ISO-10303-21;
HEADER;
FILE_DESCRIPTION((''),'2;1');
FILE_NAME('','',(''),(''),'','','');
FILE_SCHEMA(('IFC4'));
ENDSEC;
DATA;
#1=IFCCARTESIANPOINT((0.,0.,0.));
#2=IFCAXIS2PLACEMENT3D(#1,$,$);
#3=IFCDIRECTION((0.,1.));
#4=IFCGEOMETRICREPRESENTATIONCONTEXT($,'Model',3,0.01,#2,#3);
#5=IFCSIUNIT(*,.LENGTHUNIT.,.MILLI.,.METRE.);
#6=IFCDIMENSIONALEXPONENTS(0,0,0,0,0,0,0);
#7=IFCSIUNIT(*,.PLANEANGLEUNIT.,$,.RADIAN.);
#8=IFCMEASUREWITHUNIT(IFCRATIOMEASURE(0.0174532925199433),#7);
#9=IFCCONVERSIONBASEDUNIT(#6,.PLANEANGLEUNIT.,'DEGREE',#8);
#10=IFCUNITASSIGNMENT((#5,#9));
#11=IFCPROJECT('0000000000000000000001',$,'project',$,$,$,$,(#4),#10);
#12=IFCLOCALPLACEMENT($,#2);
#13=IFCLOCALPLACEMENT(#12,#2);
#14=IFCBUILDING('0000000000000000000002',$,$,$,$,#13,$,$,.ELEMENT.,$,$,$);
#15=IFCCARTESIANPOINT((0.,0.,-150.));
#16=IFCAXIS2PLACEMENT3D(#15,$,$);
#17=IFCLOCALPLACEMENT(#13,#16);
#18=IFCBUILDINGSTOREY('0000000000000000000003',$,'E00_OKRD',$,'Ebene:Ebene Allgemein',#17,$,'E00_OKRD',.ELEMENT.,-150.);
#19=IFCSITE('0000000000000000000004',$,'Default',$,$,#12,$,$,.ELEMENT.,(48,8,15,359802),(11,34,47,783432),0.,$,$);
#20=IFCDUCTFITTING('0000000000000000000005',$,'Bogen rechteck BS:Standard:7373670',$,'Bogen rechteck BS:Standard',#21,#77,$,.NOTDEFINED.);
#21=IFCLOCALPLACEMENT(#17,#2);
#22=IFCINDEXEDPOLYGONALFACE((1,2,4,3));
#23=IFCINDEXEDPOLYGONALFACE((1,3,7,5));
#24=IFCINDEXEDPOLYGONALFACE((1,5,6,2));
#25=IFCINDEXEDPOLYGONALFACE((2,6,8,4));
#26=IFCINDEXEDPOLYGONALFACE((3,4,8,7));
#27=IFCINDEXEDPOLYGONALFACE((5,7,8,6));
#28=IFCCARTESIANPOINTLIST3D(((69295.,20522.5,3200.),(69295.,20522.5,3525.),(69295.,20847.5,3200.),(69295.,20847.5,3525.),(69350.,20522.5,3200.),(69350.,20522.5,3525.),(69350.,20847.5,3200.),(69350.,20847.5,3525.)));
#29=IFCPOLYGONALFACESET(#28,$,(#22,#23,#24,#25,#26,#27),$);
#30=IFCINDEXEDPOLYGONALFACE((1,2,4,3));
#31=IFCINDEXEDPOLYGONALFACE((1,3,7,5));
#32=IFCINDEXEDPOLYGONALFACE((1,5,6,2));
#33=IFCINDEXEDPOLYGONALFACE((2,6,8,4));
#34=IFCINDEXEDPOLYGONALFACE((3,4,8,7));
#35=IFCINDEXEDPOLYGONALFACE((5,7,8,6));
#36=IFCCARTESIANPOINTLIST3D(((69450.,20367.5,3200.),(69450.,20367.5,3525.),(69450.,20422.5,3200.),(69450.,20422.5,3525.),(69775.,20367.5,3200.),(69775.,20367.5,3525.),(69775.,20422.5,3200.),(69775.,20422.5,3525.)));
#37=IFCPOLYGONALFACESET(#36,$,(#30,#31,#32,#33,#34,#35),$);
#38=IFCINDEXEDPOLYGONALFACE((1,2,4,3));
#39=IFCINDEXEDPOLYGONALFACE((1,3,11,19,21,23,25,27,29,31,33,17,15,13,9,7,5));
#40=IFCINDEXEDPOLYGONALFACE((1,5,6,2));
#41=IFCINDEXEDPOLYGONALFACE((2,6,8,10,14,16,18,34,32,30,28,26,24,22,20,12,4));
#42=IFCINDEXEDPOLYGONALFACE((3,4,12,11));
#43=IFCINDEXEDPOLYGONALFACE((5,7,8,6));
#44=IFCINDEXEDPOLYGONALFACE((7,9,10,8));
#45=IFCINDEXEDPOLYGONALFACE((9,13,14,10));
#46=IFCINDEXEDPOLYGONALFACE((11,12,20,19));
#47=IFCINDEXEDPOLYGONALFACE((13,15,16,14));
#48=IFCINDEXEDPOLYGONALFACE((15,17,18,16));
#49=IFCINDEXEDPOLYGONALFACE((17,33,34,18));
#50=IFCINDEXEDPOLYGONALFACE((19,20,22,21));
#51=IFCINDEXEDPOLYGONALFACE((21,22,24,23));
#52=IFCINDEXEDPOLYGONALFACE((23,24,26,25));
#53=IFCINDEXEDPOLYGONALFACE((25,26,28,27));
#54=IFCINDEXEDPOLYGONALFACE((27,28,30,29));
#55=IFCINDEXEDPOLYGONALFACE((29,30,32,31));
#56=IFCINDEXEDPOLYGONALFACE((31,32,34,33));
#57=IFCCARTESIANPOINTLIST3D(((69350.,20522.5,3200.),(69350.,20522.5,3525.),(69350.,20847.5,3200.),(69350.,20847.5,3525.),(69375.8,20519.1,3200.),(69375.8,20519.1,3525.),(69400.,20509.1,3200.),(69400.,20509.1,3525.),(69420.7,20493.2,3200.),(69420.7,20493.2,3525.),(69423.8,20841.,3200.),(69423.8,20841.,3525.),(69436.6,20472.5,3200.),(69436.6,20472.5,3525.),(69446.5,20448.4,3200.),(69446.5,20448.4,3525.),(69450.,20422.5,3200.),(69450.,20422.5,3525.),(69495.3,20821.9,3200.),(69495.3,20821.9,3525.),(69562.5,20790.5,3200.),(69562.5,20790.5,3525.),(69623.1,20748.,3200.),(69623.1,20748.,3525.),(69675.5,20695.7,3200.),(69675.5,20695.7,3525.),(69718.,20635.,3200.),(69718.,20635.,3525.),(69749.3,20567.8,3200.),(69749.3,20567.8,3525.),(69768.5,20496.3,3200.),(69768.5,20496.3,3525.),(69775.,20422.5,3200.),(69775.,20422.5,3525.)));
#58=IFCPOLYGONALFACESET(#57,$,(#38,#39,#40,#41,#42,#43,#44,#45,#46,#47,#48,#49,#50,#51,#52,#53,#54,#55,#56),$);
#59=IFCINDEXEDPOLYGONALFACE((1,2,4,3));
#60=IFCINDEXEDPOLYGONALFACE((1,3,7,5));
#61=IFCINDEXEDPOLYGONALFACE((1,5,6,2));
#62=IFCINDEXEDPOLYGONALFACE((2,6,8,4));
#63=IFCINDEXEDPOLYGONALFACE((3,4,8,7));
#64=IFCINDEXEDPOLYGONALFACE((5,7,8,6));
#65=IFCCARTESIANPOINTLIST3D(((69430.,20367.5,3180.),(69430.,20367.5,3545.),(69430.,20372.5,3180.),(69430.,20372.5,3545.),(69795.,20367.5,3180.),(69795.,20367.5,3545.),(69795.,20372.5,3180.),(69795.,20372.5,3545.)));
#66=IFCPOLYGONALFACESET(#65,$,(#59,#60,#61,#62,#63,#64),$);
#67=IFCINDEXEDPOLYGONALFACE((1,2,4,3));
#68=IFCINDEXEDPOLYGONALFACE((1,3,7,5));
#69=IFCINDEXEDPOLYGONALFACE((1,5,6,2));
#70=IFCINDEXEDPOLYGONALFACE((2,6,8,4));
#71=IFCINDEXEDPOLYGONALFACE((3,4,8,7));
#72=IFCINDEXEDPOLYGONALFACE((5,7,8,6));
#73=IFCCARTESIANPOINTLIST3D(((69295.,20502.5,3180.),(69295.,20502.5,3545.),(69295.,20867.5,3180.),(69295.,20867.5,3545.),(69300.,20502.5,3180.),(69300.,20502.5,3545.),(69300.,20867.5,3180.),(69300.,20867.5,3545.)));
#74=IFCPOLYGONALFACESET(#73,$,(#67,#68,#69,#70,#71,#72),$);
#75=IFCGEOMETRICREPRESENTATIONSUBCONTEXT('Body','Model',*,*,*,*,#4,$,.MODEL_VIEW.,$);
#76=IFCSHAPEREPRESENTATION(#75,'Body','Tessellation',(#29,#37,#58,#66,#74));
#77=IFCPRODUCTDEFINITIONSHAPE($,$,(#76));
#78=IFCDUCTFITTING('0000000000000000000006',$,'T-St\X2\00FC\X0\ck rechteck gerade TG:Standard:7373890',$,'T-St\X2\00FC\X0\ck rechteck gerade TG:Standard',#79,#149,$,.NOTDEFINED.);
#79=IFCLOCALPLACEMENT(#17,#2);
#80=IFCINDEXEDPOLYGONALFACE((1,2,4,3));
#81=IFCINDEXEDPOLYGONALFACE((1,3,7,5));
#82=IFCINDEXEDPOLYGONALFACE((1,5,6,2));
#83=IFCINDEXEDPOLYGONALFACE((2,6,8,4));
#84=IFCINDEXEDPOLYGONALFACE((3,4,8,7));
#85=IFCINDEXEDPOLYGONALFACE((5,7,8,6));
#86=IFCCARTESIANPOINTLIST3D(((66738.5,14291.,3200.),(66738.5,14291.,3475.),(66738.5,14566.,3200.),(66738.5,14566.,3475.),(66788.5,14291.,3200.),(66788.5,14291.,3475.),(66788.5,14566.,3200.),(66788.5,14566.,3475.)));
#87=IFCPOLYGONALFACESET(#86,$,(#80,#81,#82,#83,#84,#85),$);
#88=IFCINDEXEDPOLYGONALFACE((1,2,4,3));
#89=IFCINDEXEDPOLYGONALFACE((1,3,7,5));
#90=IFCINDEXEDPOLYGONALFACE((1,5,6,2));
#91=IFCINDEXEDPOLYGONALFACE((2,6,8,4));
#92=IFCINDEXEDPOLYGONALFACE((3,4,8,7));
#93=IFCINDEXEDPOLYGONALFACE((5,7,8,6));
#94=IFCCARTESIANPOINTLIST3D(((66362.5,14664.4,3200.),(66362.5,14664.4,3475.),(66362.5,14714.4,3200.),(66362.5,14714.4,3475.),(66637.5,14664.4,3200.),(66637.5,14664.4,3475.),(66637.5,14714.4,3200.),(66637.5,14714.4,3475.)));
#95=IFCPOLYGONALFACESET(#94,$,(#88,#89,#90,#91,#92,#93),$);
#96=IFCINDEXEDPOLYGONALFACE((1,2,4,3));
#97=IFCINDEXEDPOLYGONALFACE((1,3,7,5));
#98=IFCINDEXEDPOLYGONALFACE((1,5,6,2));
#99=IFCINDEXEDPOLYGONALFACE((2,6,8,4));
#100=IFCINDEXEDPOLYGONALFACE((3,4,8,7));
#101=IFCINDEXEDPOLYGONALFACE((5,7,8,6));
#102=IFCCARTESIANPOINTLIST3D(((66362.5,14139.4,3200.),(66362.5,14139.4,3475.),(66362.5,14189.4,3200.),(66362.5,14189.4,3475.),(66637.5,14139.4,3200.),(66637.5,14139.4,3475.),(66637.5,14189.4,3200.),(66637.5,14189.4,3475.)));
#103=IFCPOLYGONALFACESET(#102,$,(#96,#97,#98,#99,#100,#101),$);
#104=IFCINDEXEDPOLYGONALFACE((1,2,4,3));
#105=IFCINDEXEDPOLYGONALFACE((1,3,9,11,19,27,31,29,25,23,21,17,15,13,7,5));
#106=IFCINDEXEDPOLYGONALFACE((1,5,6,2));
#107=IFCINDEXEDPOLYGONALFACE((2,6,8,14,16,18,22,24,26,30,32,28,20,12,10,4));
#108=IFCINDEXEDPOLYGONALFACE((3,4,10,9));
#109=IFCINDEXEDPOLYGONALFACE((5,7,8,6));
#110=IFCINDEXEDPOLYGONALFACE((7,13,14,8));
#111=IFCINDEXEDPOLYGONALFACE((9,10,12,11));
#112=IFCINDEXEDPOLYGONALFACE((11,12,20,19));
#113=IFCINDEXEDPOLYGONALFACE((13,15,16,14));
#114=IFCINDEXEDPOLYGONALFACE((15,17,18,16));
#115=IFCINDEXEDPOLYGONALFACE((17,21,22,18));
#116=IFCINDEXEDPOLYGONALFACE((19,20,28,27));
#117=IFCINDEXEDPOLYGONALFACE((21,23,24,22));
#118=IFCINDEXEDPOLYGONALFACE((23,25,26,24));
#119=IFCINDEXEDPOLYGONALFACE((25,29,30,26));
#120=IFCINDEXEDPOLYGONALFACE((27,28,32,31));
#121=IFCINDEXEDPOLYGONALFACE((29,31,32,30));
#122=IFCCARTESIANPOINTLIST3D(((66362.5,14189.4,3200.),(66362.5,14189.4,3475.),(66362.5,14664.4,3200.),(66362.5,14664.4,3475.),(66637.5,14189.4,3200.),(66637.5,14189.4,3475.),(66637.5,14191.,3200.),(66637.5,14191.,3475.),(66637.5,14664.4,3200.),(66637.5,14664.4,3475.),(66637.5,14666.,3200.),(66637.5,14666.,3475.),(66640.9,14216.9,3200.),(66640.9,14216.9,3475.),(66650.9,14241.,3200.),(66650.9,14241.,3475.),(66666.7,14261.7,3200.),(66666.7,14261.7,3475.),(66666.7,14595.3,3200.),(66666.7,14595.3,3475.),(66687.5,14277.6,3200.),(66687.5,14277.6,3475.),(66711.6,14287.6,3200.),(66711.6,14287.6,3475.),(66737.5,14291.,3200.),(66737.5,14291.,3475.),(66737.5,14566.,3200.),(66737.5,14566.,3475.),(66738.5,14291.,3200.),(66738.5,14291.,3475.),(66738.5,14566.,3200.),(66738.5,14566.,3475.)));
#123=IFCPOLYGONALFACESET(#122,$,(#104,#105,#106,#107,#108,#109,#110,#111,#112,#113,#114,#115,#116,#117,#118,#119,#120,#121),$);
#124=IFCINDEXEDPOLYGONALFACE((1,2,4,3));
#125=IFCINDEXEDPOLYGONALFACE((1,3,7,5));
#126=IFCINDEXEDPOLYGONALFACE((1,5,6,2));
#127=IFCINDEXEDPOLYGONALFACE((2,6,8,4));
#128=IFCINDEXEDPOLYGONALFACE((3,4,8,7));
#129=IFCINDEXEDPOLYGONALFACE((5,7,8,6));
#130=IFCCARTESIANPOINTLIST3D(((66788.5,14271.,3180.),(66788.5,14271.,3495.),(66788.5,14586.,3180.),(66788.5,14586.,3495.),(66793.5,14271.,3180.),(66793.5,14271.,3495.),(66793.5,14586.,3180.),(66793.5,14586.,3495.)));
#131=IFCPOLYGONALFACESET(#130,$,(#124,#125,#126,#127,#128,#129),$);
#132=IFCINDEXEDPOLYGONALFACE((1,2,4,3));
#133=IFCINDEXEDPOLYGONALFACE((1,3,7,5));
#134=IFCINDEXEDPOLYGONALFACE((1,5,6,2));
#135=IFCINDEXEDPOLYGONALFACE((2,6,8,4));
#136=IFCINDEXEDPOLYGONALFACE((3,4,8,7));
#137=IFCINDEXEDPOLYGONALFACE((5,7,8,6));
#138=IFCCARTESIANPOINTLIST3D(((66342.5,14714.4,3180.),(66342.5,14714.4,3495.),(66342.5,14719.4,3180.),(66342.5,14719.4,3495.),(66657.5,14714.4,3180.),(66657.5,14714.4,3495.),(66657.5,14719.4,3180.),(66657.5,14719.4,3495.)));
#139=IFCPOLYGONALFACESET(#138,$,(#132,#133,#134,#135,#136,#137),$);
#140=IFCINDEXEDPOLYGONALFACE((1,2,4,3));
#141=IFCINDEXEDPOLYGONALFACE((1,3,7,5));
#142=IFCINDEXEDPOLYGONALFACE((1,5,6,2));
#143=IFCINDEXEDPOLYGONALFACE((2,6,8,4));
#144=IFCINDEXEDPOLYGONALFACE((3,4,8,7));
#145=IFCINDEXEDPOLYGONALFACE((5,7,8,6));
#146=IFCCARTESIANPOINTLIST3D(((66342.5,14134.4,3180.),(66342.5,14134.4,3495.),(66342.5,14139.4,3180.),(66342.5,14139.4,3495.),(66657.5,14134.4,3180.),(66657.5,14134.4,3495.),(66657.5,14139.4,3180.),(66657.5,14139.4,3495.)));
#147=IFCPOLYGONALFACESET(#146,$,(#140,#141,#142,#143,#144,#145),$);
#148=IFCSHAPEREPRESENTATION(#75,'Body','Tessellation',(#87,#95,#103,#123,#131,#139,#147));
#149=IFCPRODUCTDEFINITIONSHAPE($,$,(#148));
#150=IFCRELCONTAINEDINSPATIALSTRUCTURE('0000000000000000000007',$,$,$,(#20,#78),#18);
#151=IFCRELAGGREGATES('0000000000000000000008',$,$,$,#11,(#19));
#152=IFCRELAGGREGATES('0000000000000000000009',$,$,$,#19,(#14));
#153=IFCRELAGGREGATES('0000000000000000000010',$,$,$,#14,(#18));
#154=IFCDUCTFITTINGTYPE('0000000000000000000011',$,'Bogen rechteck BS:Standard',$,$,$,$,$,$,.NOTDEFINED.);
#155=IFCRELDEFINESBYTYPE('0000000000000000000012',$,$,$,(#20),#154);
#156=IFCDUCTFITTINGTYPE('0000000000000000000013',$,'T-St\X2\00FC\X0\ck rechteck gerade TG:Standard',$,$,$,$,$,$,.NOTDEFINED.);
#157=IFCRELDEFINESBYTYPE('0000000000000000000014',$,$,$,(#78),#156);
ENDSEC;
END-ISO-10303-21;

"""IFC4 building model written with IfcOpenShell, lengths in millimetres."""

from ifc_helpers import new_model, entity, si_unit, converted_unit, direction, frame, frame_2d, origin, origin_2d_with_axis, place, context, subcontext, project, spatial, polyline, circle_curve, parameter, trimmed, segment, composite_curve, rectangle, outline, extrude, source, transform, mapped, type_object, type_shapes, element, save


model = new_model("IFC4")

# Units and contexts
model_context = context("Model", 3, precision=0.01, world=origin(), true_north=direction((0.0, 1.0)))
body_context = subcontext(model_context, "Body", "Model", "MODEL_VIEW")
ifc_project = project(units=[si_unit("LENGTHUNIT", "METRE", prefix="MILLI"), converted_unit("PLANEANGLEUNIT", "DEGREE", entity("IfcRatioMeasure", 0.0174532925199433), si_unit("PLANEANGLEUNIT", "RADIAN"), dimensions=[0, 0, 0, 0, 0, 0, 0])], contexts=[model_context])

# Site, building, storey
site_placement = place(None, origin())
site = spatial("IfcSite", under=ifc_project, at=site_placement, Name="Default", CompositionType="ELEMENT", RefLatitude=(48, 8, 15, 359802), RefLongitude=(11, 34, 47, 783432), RefElevation=0.0)
building_placement = place(site_placement, origin())
building = spatial("IfcBuilding", under=site, at=building_placement, CompositionType="ELEMENT")
storey_placement = place(building_placement, frame((0.0, 0.0, -150.0)))
storey = spatial("IfcBuildingStorey", under=building, at=storey_placement, Name="E00_OKRD", ObjectType="Ebene:Ebene Allgemein", LongName="E00_OKRD", CompositionType="ELEMENT", Elevation=-150.0)

# Duct fittings
duct_fitting_type_1 = type_object("IfcDuctFittingType", Name="Bogen rechteck BS:Standard", PredefinedType="NOTDEFINED")
shared_shape_1 = source(origin(), body_context, "Body", "SweptSolid", [
    extrude(rectangle(XDim=55.0, YDim=325.0, at=frame_2d((0.0, 0.0), x_axis=(1.0, 0.0))), frame((0.0, 290.0, -162.5), z_axis=(0.0, 0.0, 1.0), x_axis=(0.0, 1.0, 0.0)), (0.0, 0.0, 1.0), 325.0),
    extrude(rectangle(XDim=325.0, YDim=55.0, at=frame_2d((0.0, 0.0), x_axis=(1.0, 0.0))), frame((-290.0, 0.0, -162.5), z_axis=(0.0, 0.0, 1.0), x_axis=(0.0, -1.0, 0.0)), (0.0, 0.0, 1.0), 325.0),
    extrude(outline(composite_curve([segment(polyline([(-293.8, -131.2), (31.2, -131.2)]), True, "CONTINUOUS"), segment(trimmed(circle_curve(frame_2d((131.2, -131.2), x_axis=(0.0, 1.0)), 100.0), [parameter(0.0)], [parameter(90.0)], True, "PARAMETER"), False, "CONTINUOUS"), segment(polyline([(131.2, -31.2), (131.2, 293.8)]), True, "CONTINUOUS"), segment(trimmed(circle_curve(frame_2d((131.2, -131.2), x_axis=(0.0, 1.0)), 425.0), [parameter(0.0)], [parameter(90.0)], True, "PARAMETER"), True, "CONTINUOUS")], self_intersect=False)), frame((-131.2, 131.3, -162.5), z_axis=(0.0, 0.0, 1.0), x_axis=(-1.0, 0.0, 0.0)), (0.0, 0.0, 1.0), 325.0),
    extrude(rectangle(XDim=5.0, YDim=365.0, at=frame_2d((0.0, 0.0), x_axis=(1.0, 0.0))), frame((-315.0, 0.0, -182.5)), (0.0, 0.0, 1.0), 365.0),
    extrude(rectangle(XDim=5.0, YDim=365.0, at=frame_2d((0.0, 0.0), x_axis=(1.0, 0.0))), frame((0.0, 315.0, -182.5), z_axis=(0.0, 0.0, 1.0), x_axis=(0.0, 1.0, 0.0)), (0.0, 0.0, 1.0), 365.0),
])
type_shapes(duct_fitting_type_1, [shared_shape_1])
duct_fitting_1_placement = place(storey_placement, frame((69612.5, 20685.0, 3362.5), z_axis=(0.0, 0.0, 1.0), x_axis=(0.0, 1.0, 0.0)))
element("IfcDuctFitting", 1, at=duct_fitting_1_placement, inside=storey, type_object=duct_fitting_type_1, Name="Bogen rechteck BS:Standard:7373670", ObjectType="Bogen rechteck BS:Standard", PredefinedType="NOTDEFINED", context=body_context, shape_type="MappedRepresentation", body=[
    mapped(shared_shape_1, transform((0.0, 0.0, 0.0), scale=1.0)),
])
duct_fitting_type_2 = type_object("IfcDuctFittingType", Name="T-Stück rechteck gerade TG:Standard", PredefinedType="NOTDEFINED")
shared_shape_2 = source(origin(), body_context, "Body", "SweptSolid", [
    extrude(rectangle(XDim=50.0, YDim=275.0, at=frame_2d((0.0, 0.0), x_axis=(1.0, 0.0))), frame((0.0, -263.5, -137.5), z_axis=(0.0, 0.0, 1.0), x_axis=(0.0, -1.0, 0.0)), (0.0, 0.0, 1.0), 275.0),
    extrude(rectangle(XDim=50.0, YDim=275.0, at=frame_2d((0.0, 0.0), x_axis=(1.0, 0.0))), frame((260.9, 0.0, -137.5), z_axis=(0.0, 0.0, 1.0), x_axis=(-1.0, 0.0, 0.0)), (0.0, 0.0, 1.0), 275.0),
    extrude(rectangle(XDim=50.0, YDim=275.0, at=origin_2d_with_axis()), frame((-264.1, 0.0, -137.5)), (0.0, 0.0, 1.0), 275.0),
    extrude(outline(composite_curve([segment(trimmed(circle_curve(frame_2d((-238.1, -114.8), x_axis=(-1.0, 0.0)), 100.0), [parameter(180.0)], [parameter(270.0)], True, "PARAMETER"), False, "CONTINUOUS"), segment(polyline([(-138.1, -114.8), (-138.1, -115.8)]), True, "CONTINUOUS"), segment(polyline([(-138.1, -115.8), (136.9, -115.8)]), True, "CONTINUOUS"), segment(polyline([(136.9, -115.8), (136.9, -114.8)]), True, "CONTINUOUS"), segment(trimmed(circle_curve(frame_2d((236.9, -114.8), x_axis=(-1.0, 0.0)), 100.0), [parameter(270.0)], [parameter(0.0)], True, "PARAMETER"), False, "CONTINUOUS"), segment(polyline([(236.9, -14.8), (238.5, -14.8)]), True, "CONTINUOUS"), segment(polyline([(238.5, -14.8), (238.5, 260.2)]), True, "CONTINUOUS"), segment(polyline([(238.5, 260.2), (-236.5, 260.2)]), True, "CONTINUOUS"), segment(polyline([(-236.5, 260.2), (-236.5, -14.8)]), True, "CONTINUOUS"), segment(polyline([(-236.5, -14.8), (-238.1, -14.8)]), True, "CONTINUOUS")], self_intersect=False)), frame((-0.6, -122.7, -137.5), z_axis=(0.0, 0.0, -1.0), x_axis=(-1.0, 0.0, 0.0)), (0.0, 0.0, -1.0), 275.0),
    extrude(rectangle(XDim=5.0, YDim=315.0, at=frame_2d((0.0, 0.0), x_axis=(1.0, 0.0))), frame((0.0, -291.0, -157.5), z_axis=(0.0, 0.0, 1.0), x_axis=(0.0, 1.0, 0.0)), (0.0, 0.0, 1.0), 315.0),
    extrude(rectangle(XDim=5.0, YDim=315.0, at=origin_2d_with_axis()), frame((288.4, 0.0, -157.5), z_axis=(0.0, 0.0, 1.0), x_axis=(-1.0, 0.0, 0.0)), (0.0, 0.0, 1.0), 315.0),
    extrude(rectangle(XDim=5.0, YDim=315.0, at=frame_2d((0.0, 0.0), x_axis=(1.0, 0.0))), frame((-291.6, 0.0, -157.5), z_axis=(0.0, 0.0, 1.0), x_axis=(-1.0, 0.0, 0.0)), (0.0, 0.0, 1.0), 315.0),
])
type_shapes(duct_fitting_type_2, [shared_shape_2])
duct_fitting_2_placement = place(storey_placement, frame((66500.0, 14428.5, 3337.5), z_axis=(0.0, 0.0, 1.0), x_axis=(0.0, 1.0, 0.0)))
element("IfcDuctFitting", 2, at=duct_fitting_2_placement, inside=storey, type_object=duct_fitting_type_2, Name="T-Stück rechteck gerade TG:Standard:7373890", ObjectType="T-Stück rechteck gerade TG:Standard", PredefinedType="NOTDEFINED", context=body_context, shape_type="MappedRepresentation", body=[
    mapped(shared_shape_2, transform((0.0, 0.0, 0.0), scale=1.0)),
])

save(model, "model.ifc")
